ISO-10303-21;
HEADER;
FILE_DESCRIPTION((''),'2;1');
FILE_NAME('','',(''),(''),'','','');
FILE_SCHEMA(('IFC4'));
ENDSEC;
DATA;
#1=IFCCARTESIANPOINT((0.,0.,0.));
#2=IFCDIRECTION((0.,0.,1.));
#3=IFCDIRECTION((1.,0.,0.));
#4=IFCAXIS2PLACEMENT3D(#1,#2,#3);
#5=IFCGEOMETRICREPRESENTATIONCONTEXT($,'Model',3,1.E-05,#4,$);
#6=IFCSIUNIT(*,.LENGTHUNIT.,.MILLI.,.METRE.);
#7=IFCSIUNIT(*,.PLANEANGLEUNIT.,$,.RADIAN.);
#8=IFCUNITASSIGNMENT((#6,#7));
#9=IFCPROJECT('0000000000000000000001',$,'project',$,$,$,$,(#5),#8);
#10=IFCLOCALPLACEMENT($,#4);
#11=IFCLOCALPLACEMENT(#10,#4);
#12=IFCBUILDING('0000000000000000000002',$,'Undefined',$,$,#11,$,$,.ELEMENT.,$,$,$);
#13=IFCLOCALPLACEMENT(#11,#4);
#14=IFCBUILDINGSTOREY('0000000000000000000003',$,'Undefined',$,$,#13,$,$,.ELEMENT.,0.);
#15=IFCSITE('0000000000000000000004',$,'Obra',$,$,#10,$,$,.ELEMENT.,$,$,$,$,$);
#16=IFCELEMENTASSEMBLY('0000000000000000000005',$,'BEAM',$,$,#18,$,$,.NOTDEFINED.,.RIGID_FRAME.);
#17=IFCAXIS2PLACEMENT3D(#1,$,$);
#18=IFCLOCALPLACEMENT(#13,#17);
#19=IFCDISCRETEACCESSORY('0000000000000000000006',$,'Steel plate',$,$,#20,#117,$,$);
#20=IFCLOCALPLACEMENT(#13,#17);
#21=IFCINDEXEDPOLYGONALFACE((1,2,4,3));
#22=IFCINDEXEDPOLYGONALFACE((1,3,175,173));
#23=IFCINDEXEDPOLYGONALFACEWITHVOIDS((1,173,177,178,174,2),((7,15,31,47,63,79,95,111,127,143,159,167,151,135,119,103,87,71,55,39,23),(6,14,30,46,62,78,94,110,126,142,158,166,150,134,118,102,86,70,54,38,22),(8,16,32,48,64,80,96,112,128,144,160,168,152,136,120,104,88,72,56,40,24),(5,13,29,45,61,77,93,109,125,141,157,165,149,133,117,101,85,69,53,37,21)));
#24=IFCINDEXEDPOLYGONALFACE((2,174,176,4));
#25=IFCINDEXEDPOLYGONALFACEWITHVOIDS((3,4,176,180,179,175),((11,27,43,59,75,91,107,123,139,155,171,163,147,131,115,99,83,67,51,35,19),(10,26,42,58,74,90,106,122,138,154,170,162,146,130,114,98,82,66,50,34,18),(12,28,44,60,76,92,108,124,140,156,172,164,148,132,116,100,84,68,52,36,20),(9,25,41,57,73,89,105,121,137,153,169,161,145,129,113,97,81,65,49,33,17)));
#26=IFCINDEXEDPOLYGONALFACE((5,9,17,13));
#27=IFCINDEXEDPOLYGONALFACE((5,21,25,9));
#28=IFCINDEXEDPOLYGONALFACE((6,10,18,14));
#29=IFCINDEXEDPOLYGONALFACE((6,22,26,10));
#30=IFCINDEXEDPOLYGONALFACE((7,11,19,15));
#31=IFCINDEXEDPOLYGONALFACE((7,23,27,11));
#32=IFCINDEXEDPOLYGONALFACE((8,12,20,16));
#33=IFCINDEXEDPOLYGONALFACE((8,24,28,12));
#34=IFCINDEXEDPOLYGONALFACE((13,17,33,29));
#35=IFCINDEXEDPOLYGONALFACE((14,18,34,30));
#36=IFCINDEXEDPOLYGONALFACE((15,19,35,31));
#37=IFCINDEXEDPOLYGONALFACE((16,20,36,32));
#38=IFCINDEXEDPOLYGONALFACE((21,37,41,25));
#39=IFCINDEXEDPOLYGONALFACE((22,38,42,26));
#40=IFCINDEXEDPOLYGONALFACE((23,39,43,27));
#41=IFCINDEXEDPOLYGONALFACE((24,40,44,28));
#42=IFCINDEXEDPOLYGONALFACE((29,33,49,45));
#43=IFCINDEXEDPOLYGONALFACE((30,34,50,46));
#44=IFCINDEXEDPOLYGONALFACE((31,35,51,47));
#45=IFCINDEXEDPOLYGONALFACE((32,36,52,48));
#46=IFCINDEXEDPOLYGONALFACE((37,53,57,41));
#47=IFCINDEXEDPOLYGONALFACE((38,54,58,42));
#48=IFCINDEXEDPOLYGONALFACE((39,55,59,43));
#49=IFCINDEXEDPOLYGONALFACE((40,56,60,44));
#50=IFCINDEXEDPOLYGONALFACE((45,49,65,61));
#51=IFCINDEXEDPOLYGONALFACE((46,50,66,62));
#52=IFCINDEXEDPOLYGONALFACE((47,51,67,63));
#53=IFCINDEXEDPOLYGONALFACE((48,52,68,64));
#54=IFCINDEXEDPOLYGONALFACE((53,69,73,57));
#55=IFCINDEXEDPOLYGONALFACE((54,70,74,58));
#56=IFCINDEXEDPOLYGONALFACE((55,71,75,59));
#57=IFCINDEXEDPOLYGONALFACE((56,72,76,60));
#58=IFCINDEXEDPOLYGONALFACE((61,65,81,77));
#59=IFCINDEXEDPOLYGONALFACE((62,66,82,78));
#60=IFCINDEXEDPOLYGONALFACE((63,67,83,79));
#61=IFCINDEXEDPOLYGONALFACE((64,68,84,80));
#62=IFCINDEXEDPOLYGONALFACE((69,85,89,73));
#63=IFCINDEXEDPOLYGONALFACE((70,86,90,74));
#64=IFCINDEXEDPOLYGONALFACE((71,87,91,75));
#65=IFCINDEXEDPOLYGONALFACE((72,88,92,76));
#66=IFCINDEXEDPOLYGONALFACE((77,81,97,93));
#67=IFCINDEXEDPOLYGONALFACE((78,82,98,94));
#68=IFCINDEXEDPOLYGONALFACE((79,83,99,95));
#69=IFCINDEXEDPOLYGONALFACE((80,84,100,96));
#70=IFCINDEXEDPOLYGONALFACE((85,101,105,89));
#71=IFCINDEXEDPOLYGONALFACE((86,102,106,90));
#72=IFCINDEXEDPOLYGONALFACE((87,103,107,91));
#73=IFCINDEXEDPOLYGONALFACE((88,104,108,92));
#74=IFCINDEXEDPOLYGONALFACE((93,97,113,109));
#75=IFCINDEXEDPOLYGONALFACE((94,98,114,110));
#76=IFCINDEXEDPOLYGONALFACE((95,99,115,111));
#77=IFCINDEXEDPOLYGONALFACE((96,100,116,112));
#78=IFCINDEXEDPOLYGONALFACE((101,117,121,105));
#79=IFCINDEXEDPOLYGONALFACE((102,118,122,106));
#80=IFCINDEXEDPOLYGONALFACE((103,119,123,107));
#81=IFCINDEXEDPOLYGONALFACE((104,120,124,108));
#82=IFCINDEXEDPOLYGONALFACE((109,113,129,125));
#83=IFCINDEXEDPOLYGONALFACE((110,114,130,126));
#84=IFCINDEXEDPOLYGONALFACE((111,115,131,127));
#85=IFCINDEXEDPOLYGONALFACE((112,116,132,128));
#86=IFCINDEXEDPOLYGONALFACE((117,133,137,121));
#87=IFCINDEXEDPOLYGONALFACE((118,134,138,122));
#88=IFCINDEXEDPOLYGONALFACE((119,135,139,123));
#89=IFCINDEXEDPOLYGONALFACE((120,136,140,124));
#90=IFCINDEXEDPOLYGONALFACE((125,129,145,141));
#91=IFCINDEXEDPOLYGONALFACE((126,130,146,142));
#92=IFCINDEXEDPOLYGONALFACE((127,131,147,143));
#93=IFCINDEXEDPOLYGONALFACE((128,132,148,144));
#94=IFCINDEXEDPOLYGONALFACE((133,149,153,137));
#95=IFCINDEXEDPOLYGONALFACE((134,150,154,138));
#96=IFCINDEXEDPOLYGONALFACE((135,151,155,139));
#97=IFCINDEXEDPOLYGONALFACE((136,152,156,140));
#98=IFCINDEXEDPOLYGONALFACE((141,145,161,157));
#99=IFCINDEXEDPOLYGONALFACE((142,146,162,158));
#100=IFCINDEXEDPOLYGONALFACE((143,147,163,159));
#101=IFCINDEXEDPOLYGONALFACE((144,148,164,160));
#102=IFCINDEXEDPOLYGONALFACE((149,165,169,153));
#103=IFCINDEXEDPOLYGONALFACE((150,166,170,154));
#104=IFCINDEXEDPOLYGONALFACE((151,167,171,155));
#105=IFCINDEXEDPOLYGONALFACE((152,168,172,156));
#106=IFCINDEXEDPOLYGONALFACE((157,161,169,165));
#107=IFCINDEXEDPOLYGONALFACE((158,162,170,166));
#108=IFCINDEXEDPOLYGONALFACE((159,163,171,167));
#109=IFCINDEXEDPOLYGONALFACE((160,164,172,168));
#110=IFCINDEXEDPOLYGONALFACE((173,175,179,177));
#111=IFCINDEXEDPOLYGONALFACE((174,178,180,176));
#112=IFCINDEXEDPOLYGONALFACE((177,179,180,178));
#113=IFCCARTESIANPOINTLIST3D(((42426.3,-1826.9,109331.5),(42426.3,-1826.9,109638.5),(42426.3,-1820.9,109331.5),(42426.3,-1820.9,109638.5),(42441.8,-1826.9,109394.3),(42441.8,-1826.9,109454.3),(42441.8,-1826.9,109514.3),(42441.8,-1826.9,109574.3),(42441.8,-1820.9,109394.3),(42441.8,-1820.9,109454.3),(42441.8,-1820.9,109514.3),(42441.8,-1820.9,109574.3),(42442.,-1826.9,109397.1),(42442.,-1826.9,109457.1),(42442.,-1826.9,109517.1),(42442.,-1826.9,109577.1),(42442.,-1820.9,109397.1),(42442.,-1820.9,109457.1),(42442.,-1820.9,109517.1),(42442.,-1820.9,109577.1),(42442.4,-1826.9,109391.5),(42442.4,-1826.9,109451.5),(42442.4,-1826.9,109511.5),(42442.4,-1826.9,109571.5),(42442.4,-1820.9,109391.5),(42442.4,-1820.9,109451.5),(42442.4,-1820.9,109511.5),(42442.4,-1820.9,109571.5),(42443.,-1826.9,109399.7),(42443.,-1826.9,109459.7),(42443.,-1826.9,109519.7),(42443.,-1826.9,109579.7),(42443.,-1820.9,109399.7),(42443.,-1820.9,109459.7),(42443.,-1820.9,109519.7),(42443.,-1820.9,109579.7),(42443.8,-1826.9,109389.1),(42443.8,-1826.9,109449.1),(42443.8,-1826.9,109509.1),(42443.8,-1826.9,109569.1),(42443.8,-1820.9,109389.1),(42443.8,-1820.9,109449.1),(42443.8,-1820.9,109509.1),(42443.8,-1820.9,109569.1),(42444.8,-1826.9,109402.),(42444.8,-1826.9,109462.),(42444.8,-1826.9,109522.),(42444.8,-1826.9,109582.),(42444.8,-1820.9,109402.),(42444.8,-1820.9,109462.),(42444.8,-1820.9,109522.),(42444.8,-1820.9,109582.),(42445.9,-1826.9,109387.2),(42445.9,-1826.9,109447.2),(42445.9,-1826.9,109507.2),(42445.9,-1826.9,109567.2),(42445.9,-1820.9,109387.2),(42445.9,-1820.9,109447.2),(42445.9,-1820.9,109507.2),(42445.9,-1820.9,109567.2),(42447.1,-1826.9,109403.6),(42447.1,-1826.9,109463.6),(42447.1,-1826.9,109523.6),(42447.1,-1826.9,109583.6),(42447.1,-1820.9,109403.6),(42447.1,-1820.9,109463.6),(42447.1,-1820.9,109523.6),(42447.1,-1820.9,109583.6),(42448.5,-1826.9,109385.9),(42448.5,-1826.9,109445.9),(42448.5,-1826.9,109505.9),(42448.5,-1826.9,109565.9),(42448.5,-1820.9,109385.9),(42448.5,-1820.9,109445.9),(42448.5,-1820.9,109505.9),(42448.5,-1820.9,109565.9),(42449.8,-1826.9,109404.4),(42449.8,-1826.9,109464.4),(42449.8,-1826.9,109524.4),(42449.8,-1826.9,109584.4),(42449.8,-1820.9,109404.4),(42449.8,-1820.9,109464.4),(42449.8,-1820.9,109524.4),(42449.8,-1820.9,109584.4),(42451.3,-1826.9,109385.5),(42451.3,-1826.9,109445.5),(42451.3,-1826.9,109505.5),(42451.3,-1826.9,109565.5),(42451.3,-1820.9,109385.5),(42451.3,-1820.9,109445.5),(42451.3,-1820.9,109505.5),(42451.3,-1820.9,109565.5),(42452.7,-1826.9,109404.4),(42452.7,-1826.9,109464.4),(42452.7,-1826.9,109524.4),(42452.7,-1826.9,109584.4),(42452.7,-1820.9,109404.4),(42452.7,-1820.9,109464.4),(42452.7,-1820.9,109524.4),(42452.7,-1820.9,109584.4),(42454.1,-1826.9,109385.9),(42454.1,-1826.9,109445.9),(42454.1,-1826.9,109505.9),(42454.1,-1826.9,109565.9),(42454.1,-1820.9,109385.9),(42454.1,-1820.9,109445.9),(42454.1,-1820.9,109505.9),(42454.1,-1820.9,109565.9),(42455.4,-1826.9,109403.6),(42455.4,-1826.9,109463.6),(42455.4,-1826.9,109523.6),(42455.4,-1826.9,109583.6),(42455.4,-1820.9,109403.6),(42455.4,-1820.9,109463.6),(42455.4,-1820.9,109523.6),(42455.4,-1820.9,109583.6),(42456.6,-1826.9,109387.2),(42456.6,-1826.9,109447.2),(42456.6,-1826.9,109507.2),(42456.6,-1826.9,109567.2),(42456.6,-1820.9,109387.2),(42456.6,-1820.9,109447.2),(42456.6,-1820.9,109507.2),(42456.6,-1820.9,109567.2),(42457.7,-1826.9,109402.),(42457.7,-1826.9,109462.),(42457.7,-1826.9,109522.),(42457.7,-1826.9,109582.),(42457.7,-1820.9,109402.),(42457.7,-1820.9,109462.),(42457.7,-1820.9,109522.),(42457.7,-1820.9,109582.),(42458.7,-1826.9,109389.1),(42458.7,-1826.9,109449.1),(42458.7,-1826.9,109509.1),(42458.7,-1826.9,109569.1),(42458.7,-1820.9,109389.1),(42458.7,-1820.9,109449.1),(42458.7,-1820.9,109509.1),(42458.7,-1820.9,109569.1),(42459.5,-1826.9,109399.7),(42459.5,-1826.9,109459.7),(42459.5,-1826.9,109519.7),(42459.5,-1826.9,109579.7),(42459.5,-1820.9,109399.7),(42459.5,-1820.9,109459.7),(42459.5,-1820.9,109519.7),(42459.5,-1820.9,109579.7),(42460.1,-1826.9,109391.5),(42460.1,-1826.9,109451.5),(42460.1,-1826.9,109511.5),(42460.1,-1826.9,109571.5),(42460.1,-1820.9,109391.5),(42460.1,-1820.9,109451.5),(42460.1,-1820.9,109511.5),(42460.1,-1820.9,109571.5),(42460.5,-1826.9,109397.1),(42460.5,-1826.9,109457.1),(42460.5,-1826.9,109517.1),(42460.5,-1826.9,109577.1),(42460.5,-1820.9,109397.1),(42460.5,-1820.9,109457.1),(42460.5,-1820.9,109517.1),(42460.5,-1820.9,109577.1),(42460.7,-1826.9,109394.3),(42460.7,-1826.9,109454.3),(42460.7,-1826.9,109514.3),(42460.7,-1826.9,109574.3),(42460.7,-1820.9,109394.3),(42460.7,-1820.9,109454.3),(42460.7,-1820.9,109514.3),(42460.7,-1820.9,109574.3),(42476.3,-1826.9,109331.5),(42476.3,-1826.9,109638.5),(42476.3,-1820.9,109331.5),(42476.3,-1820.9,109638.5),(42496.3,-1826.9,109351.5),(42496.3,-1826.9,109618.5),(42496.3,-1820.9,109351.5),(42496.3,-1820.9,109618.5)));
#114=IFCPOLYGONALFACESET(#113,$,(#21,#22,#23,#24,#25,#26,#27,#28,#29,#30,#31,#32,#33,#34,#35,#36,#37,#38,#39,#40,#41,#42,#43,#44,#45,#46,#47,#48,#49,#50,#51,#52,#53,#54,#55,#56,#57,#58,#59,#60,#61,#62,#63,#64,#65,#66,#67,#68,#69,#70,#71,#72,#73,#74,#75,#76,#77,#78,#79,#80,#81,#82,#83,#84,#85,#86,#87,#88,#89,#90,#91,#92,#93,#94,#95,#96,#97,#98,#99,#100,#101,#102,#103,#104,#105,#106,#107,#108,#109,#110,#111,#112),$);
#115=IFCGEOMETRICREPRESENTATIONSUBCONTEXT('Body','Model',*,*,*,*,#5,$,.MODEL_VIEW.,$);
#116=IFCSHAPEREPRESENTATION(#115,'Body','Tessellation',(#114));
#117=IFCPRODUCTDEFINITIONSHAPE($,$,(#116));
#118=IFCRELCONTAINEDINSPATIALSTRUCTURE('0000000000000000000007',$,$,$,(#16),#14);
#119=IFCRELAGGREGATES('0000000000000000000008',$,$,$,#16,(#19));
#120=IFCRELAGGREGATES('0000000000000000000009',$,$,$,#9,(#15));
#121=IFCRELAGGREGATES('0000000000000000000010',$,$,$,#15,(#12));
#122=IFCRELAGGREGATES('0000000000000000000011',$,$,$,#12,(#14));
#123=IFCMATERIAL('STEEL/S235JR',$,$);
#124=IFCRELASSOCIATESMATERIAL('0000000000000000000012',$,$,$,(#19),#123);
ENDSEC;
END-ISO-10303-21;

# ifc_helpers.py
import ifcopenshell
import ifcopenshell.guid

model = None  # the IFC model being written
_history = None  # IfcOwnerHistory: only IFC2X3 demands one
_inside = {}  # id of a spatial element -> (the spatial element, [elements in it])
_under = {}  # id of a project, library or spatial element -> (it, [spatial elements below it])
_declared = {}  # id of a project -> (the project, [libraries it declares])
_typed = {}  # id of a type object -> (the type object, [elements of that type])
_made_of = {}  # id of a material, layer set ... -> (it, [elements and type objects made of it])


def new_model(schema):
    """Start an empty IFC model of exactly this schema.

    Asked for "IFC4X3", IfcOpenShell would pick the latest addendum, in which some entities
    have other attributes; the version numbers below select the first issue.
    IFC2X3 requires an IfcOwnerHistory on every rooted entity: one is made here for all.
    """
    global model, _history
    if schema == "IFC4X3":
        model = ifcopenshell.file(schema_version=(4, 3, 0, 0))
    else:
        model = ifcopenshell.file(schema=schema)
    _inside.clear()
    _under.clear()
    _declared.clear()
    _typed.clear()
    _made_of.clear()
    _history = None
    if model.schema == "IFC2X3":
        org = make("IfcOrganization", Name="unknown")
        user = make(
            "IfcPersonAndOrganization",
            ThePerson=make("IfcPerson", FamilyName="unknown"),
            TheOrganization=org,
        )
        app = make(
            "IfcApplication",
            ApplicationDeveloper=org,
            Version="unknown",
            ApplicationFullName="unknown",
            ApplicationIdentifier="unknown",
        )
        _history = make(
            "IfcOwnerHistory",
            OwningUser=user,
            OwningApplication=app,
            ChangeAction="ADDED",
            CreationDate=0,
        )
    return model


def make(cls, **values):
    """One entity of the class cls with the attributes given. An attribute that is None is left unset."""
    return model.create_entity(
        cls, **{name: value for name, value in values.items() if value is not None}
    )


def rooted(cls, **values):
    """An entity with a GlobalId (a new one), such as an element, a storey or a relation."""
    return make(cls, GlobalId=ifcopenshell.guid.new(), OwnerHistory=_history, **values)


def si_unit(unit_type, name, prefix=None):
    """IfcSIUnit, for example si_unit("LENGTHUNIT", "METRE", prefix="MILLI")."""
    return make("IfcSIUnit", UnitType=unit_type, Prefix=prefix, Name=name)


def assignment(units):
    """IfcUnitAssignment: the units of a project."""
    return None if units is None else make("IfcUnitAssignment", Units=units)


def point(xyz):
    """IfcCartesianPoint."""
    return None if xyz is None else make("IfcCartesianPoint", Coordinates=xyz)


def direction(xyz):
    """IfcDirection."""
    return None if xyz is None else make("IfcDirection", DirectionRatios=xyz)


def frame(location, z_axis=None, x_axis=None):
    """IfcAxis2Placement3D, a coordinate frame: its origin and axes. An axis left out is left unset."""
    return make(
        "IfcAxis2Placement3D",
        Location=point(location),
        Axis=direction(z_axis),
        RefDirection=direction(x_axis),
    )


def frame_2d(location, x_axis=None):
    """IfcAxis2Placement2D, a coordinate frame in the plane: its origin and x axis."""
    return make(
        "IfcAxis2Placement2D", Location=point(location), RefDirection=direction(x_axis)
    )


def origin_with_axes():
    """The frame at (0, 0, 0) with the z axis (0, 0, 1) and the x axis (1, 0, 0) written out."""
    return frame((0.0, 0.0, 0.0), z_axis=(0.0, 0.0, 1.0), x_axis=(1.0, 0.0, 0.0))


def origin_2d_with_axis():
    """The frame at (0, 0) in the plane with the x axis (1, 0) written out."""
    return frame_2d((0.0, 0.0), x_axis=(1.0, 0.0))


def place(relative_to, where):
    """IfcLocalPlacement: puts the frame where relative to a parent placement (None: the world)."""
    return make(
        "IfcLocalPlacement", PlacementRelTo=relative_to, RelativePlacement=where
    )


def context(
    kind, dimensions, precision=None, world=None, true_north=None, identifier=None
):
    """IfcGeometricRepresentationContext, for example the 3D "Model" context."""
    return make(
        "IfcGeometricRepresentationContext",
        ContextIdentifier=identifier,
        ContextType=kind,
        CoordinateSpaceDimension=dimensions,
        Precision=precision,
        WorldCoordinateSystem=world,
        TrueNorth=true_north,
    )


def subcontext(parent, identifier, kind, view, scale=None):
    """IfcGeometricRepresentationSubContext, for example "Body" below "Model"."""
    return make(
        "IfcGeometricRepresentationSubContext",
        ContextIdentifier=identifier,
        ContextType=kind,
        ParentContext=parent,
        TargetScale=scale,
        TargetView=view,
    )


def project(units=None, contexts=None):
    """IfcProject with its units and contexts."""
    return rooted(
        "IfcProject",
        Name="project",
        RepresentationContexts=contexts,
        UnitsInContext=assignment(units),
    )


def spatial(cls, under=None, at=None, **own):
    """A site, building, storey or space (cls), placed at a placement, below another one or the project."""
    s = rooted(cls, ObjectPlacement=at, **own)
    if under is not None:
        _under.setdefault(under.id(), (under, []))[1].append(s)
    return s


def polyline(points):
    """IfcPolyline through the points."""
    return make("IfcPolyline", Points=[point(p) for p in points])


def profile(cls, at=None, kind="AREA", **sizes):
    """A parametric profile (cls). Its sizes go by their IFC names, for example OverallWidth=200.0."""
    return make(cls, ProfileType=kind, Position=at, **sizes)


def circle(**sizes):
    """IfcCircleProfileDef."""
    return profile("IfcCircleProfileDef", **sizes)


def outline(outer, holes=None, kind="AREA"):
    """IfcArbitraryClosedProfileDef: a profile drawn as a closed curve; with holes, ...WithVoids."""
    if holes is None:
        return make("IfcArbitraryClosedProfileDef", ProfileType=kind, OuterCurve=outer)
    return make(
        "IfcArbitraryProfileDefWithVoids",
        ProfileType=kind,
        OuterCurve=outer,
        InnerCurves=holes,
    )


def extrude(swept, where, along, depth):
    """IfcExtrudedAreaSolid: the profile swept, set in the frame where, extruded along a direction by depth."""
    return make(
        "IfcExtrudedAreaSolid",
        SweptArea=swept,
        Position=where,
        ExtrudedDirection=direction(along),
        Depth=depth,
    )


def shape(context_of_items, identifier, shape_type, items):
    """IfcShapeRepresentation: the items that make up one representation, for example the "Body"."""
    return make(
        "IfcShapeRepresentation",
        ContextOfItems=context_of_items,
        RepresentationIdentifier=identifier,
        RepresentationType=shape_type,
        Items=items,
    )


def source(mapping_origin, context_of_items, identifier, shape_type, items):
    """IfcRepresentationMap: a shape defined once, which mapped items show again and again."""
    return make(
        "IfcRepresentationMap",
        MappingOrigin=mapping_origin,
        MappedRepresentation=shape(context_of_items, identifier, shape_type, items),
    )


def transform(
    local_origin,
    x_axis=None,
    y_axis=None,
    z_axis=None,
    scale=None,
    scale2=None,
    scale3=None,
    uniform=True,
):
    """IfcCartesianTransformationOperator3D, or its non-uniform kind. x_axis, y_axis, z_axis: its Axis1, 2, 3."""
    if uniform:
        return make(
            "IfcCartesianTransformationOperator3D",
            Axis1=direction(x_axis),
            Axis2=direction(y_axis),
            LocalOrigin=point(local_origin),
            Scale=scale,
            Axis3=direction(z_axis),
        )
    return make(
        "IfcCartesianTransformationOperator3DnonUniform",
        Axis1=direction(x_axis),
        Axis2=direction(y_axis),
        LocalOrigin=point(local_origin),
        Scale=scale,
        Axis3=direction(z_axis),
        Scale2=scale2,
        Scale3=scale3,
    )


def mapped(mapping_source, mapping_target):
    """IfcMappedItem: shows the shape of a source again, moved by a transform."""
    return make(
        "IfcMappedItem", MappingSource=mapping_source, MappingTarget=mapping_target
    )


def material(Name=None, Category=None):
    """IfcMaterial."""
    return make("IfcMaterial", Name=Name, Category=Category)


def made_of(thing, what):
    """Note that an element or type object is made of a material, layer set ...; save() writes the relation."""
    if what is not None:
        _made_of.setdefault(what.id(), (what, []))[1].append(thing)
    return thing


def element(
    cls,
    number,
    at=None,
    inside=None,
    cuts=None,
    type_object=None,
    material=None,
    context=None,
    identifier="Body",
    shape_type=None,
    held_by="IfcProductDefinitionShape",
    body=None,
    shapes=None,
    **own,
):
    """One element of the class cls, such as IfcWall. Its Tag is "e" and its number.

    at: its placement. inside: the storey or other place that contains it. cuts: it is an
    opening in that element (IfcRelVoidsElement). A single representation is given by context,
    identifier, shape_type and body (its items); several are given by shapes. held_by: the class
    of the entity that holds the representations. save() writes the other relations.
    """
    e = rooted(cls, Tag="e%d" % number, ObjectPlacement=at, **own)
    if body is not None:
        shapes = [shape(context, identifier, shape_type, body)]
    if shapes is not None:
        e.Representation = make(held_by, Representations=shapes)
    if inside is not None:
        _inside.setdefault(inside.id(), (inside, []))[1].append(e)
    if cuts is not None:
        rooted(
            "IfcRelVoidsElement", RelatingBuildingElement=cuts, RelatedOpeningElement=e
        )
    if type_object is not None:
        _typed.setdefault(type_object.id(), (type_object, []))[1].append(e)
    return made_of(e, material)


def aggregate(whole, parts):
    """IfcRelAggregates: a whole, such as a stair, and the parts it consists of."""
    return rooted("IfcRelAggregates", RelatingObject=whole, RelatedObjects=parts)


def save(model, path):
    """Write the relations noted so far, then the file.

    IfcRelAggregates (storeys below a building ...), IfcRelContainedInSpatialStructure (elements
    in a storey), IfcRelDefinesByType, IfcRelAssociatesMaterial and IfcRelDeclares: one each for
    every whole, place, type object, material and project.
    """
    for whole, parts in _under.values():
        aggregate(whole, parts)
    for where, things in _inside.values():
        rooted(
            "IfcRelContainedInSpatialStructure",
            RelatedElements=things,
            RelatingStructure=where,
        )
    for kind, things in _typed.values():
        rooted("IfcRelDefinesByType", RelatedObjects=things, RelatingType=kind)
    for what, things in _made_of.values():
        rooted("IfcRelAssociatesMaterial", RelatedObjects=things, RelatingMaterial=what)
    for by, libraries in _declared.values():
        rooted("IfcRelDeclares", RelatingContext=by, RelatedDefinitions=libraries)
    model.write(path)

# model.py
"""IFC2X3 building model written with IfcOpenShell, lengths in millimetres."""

from ifc_helpers import new_model, si_unit, frame, origin_with_axes, origin_2d_with_axis, place, context, subcontext, project, spatial, polyline, circle, outline, extrude, source, transform, mapped, material, element, aggregate, save


model = new_model("IFC2X3")

# Units and contexts
model_context = context("Model", 3, precision=1e-05, world=origin_with_axes())
body_context = subcontext(model_context, "Body", "Model", "MODEL_VIEW")
ifc_project = project(units=[si_unit("LENGTHUNIT", "METRE", prefix="MILLI"), si_unit("PLANEANGLEUNIT", "RADIAN")], contexts=[model_context])

# Site, building, storey
site_placement = place(None, origin_with_axes())
site = spatial("IfcSite", under=ifc_project, at=site_placement, Name="Obra", CompositionType="ELEMENT")
building_placement = place(site_placement, origin_with_axes())
building = spatial("IfcBuilding", under=site, at=building_placement, Name="Undefined", CompositionType="ELEMENT")
storey_placement = place(building_placement, origin_with_axes())
storey = spatial("IfcBuildingStorey", under=building, at=storey_placement, Name="Undefined", CompositionType="ELEMENT", Elevation=0.0)

# Element assembly, discrete accessory, opening
ifc_material = material(Name="STEEL/S235JR")
shared_shape = source(origin_with_axes(), body_context, "Body", "SweptSolid", [
    extrude(circle(Radius=9.5, at=origin_2d_with_axis()), frame((0.0, -9.8, 0.0), z_axis=(0.0, 1.0, 0.0), x_axis=(1.0, 0.0, 0.0)), (0.0, 0.0, 1.0), 6.2),
])
assembly_1_placement = place(storey_placement, origin_with_axes())
assembly_1 = element("IfcElementAssembly", 1, at=assembly_1_placement, inside=storey, Name="BEAM", AssemblyPlace="NOTDEFINED", PredefinedType="RIGID_FRAME")
discrete_accessory_1_placement = place(assembly_1_placement, frame((42426.3, -1823.9, 109331.5), z_axis=(-0.000012, -1.0, 0.0), x_axis=(1.0, -0.000012, 0.0)))
discrete_accessory_1 = element("IfcDiscreteAccessory", 2, at=discrete_accessory_1_placement, material=ifc_material, Name="Steel plate", context=body_context, shape_type="SweptSolid", body=[
    extrude(outline(polyline([(0.0, 0.0), (50.0, 0.0), (70.0, 20.0), (70.0, 287.0), (50.0, 307.0), (0.0, 307.0), (0.0, 0.0)])), frame((0.0, 0.0, -3.0), z_axis=(0.0, 0.0, 1.0), x_axis=(1.0, 0.0, 0.0)), (0.0, 0.0, 1.0), 6.0),
])
opening_1_placement = place(assembly_1_placement, frame((42486.3, -1830.7, 109650.0), z_axis=(-1.0, 0.000012, 0.0), x_axis=(0.0, 0.0, -1.0)))
element("IfcOpeningElement", 3, at=opening_1_placement, cuts=discrete_accessory_1, ObjectType="Opening", context=body_context, shape_type="MappedRepresentation", body=[
    mapped(shared_shape, transform((75.0, 0.0, 35.0))),
    mapped(shared_shape, transform((135.0, 0.0, 35.0))),
    mapped(shared_shape, transform((195.0, 0.0, 35.0))),
    mapped(shared_shape, transform((255.0, 0.0, 35.0))),
])
aggregate(assembly_1, [discrete_accessory_1])

save(model, "model.ifc")
